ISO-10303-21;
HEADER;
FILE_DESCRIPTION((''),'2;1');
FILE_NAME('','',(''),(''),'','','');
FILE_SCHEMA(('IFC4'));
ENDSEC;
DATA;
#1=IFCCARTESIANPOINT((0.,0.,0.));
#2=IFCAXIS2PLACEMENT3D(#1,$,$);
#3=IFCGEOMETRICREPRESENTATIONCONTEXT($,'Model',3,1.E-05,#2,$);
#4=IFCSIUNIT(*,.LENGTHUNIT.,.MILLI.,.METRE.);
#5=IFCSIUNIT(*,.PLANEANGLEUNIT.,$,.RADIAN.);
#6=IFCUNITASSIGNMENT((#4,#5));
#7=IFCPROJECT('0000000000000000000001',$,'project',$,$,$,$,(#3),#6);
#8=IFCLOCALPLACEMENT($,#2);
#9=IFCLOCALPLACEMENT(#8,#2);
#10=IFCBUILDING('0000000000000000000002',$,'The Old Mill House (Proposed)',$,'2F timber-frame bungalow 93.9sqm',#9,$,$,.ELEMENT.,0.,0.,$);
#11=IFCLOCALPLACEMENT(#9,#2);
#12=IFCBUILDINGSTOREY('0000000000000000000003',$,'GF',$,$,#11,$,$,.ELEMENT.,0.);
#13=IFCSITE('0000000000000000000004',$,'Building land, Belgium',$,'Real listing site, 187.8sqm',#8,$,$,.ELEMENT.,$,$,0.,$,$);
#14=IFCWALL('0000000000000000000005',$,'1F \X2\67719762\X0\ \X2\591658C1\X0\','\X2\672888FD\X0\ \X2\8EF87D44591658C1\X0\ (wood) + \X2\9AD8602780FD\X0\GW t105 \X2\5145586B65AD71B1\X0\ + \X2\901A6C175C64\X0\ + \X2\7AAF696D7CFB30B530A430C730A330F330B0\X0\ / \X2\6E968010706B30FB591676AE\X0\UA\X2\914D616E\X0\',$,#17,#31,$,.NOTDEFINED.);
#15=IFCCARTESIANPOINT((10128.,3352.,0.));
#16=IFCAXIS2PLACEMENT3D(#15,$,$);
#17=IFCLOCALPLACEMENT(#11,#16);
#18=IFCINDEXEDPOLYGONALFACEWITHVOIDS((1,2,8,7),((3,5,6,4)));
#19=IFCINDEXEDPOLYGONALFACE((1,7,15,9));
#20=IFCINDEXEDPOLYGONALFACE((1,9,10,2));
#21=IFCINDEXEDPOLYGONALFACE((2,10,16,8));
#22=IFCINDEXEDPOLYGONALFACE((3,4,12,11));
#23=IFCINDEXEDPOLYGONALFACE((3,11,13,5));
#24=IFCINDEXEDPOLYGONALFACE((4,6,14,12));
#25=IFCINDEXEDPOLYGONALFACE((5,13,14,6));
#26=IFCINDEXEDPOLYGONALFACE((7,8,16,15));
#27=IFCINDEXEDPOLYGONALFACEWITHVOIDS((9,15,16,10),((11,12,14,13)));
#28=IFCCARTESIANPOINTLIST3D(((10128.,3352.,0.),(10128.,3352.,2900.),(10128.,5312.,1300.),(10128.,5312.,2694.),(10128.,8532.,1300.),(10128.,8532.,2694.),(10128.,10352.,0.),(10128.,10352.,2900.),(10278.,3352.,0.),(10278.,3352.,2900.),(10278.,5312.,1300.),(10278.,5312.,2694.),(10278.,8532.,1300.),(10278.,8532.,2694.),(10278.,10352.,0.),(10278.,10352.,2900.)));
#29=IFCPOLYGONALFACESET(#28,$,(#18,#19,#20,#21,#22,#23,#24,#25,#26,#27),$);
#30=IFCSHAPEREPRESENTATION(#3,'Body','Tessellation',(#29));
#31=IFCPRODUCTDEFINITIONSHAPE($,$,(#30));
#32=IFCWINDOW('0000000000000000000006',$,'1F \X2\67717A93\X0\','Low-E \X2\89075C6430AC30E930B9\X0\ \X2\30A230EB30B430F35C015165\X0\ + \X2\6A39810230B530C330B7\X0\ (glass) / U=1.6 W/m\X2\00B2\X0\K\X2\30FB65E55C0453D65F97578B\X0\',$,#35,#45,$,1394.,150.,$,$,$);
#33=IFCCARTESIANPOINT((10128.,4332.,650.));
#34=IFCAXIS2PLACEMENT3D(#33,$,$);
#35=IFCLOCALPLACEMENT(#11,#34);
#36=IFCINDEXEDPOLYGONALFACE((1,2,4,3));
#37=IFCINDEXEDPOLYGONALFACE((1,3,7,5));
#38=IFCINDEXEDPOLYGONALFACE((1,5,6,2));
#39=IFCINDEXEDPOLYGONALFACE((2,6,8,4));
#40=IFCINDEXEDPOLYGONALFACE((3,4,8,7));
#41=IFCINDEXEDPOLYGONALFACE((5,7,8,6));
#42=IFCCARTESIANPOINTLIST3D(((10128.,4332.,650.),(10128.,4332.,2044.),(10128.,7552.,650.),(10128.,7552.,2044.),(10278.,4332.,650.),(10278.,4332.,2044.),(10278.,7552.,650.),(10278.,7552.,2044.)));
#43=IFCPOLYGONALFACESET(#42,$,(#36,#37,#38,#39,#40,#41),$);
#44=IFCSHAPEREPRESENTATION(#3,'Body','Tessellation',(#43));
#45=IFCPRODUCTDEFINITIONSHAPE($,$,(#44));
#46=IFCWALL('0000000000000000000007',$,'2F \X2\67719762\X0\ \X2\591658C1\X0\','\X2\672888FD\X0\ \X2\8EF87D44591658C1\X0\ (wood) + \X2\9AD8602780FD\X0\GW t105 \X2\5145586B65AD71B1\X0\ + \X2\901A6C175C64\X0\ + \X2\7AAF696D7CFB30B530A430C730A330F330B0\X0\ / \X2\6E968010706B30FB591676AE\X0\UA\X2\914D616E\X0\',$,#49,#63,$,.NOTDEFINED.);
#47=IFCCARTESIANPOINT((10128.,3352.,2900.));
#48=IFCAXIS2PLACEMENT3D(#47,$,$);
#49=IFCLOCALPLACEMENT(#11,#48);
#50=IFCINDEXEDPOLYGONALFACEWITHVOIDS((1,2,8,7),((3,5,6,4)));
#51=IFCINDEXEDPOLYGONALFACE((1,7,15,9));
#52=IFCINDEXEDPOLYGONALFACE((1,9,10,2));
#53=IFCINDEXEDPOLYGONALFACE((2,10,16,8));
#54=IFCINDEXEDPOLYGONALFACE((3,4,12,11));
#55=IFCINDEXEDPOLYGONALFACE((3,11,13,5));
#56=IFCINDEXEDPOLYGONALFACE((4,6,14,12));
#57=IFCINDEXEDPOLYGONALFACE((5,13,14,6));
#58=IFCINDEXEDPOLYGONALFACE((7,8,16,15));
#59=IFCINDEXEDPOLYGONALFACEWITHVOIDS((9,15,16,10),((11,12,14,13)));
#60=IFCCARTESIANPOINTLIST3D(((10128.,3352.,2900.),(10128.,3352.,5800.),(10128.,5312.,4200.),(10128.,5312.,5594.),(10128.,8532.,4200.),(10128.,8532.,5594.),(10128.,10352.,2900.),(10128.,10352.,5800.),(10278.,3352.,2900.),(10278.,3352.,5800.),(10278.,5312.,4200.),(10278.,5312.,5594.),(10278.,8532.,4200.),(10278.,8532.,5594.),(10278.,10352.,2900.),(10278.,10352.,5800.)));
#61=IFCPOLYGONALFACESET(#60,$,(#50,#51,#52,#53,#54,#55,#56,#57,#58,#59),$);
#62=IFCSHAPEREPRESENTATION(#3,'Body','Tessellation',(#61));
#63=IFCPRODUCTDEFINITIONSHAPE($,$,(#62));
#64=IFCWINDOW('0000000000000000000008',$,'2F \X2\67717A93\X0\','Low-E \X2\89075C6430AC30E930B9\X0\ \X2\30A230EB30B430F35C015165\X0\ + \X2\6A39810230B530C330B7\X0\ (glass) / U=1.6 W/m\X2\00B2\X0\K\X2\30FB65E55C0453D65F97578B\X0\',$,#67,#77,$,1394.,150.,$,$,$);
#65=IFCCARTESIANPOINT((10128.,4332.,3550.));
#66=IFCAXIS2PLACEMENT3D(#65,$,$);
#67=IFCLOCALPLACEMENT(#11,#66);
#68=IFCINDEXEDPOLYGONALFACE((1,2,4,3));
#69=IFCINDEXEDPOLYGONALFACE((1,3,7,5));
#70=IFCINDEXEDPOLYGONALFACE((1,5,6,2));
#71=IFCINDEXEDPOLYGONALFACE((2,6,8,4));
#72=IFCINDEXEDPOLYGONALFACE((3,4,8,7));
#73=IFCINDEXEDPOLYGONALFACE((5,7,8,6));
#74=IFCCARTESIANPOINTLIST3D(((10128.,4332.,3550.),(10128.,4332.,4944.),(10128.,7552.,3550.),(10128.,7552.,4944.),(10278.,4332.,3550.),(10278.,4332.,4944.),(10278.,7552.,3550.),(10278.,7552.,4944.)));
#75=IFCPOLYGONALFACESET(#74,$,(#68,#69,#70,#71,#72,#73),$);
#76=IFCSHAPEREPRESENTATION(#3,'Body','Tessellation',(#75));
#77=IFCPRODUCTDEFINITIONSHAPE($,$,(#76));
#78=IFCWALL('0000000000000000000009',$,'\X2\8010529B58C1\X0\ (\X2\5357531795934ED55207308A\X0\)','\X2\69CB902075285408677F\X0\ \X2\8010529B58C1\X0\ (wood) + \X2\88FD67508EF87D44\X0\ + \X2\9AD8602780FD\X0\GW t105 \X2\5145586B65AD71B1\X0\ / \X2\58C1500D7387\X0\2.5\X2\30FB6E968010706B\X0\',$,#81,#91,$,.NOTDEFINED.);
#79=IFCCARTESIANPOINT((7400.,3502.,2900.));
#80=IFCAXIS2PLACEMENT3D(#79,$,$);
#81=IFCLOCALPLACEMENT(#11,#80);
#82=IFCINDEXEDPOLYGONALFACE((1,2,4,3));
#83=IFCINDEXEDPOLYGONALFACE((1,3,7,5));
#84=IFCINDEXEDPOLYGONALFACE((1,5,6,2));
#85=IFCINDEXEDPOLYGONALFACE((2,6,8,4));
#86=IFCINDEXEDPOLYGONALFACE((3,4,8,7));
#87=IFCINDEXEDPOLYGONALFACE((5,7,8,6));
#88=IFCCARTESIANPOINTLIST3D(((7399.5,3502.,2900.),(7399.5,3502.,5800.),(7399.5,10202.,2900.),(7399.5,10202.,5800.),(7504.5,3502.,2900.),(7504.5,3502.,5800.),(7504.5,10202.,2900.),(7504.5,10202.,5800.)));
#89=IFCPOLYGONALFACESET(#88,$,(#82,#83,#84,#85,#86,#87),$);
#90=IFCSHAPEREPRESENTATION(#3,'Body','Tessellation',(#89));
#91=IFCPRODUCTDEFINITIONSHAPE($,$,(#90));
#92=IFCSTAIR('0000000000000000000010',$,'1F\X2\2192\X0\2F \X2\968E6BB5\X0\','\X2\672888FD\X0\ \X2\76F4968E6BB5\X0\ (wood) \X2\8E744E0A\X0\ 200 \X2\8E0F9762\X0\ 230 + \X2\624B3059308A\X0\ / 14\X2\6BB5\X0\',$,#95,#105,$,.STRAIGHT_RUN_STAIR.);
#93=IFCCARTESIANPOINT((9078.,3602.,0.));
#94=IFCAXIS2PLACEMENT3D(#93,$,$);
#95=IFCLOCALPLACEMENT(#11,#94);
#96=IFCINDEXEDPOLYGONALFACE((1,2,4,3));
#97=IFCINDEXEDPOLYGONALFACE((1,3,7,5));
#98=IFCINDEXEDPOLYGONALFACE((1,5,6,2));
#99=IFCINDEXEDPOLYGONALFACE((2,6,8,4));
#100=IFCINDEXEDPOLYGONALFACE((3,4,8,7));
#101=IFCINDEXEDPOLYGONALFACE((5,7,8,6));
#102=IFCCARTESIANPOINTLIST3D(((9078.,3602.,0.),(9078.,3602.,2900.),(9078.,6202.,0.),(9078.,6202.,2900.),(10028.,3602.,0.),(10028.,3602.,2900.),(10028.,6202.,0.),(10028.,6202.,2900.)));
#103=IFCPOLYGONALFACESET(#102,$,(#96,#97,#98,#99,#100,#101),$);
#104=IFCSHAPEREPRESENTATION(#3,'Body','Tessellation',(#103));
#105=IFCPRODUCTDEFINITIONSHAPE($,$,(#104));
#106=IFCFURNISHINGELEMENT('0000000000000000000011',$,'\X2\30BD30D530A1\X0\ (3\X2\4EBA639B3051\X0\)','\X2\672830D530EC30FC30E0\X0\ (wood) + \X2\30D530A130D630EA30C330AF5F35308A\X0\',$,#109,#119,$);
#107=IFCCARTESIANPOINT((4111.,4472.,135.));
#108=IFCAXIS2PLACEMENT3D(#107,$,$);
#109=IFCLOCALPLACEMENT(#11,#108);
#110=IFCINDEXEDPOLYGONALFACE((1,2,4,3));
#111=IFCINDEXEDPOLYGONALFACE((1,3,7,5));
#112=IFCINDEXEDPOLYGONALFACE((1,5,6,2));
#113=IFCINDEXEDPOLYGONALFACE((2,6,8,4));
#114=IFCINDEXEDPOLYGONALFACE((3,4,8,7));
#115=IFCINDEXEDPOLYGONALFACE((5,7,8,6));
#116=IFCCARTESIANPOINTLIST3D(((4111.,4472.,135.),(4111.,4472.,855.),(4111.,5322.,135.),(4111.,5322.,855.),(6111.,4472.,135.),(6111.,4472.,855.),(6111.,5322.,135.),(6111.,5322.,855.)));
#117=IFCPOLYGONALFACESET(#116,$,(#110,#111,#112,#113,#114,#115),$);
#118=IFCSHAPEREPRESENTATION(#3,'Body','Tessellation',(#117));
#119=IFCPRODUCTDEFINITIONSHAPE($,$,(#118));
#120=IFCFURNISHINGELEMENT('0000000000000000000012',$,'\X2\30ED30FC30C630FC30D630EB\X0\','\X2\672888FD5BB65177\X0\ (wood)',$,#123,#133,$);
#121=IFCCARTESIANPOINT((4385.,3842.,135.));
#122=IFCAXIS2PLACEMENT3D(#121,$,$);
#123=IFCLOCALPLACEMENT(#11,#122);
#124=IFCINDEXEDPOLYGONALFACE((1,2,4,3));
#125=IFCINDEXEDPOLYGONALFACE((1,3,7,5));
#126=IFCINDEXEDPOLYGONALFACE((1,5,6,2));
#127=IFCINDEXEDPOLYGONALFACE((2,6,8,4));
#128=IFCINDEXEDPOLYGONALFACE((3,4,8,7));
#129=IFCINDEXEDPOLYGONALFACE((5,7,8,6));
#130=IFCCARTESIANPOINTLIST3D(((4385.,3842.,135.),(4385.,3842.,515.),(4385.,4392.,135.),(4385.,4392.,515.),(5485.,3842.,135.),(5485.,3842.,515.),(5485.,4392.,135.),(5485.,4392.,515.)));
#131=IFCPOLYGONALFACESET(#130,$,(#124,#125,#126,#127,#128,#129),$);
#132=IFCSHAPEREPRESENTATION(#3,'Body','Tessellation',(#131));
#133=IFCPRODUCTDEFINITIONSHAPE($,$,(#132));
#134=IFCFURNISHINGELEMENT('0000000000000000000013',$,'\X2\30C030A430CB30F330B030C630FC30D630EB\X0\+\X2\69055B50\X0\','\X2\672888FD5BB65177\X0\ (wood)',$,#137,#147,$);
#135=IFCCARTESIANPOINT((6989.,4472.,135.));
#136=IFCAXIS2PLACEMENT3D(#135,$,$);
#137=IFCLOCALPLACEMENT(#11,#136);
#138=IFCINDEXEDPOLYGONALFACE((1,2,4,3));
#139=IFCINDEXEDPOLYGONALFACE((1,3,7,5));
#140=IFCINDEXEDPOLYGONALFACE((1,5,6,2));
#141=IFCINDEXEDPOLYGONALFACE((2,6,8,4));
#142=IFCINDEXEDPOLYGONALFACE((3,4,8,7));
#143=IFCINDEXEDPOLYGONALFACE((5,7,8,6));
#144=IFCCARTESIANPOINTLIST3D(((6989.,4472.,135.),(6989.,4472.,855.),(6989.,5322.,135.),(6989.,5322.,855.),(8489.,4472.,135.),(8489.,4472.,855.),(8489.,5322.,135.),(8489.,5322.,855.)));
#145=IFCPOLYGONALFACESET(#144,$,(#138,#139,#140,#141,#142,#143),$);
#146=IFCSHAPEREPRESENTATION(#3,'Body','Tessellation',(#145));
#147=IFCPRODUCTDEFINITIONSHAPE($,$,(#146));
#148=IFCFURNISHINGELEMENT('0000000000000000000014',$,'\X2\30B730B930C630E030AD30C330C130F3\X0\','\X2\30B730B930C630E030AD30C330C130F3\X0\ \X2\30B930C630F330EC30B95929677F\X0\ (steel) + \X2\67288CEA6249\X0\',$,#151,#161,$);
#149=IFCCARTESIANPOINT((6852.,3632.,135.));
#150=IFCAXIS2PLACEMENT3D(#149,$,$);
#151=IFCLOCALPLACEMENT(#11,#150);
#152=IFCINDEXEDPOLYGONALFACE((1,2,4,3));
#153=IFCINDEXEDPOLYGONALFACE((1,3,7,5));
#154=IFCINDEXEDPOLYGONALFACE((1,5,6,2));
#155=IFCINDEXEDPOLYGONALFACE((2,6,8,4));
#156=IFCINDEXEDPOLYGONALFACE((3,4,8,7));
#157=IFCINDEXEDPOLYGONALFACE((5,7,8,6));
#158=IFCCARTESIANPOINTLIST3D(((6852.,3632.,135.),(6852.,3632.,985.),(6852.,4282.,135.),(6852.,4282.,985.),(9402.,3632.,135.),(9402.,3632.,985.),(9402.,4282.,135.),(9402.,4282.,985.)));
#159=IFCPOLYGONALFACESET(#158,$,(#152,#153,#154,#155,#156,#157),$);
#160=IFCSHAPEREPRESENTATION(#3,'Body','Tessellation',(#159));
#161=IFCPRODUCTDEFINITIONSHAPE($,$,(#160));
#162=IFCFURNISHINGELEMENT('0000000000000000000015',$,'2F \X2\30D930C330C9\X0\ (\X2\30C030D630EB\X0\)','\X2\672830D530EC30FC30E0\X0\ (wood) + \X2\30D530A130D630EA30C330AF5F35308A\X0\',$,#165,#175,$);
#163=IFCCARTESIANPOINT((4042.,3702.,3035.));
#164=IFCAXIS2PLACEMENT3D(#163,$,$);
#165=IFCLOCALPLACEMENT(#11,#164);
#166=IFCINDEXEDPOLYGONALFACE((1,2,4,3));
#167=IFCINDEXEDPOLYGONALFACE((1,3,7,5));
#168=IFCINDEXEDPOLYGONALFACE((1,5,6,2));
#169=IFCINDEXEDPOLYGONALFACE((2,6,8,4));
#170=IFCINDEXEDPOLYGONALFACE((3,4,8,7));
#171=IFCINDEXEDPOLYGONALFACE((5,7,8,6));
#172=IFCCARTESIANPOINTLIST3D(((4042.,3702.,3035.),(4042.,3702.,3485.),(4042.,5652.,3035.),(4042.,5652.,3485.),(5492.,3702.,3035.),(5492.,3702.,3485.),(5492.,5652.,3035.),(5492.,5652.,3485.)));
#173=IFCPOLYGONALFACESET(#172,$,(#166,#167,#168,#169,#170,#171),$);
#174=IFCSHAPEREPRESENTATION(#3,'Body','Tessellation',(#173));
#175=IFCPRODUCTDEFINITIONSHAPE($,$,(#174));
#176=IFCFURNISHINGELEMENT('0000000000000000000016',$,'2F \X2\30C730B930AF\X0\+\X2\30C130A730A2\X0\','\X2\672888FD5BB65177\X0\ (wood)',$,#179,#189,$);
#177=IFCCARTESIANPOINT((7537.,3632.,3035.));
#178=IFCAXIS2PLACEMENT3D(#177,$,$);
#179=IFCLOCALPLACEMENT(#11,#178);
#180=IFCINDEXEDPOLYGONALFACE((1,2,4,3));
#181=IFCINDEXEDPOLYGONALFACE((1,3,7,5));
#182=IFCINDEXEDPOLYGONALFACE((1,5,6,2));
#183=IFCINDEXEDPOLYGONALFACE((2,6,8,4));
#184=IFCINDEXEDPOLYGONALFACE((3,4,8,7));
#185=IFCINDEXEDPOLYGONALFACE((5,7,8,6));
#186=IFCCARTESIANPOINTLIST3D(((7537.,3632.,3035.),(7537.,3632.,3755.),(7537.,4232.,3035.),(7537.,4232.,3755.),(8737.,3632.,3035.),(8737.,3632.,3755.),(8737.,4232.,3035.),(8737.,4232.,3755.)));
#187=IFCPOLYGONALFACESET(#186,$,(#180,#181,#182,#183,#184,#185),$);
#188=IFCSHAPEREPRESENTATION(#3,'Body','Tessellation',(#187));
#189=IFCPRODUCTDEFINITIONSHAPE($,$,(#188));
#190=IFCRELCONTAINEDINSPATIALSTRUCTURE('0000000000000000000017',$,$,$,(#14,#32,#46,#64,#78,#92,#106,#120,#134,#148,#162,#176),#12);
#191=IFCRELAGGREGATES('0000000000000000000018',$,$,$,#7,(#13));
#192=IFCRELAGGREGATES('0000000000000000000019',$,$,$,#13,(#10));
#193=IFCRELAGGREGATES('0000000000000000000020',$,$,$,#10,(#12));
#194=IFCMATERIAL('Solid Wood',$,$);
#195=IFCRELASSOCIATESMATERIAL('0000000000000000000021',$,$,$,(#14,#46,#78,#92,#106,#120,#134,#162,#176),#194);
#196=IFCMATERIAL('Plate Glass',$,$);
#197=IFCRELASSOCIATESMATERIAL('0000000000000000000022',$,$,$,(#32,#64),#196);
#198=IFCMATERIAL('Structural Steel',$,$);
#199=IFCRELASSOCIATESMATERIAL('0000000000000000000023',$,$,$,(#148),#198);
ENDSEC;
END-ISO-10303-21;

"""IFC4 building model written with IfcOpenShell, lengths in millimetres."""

from ifc_helpers import new_model, si_unit, frame, frame_2d, origin, place, context, project, spatial, rectangle, extrude, material, element, fill, save


model = new_model("IFC4")

# Units and contexts
model_context = context("Model", 3, precision=1e-05, world=origin())
ifc_project = project(units=[si_unit("LENGTHUNIT", "METRE", prefix="MILLI"), si_unit("PLANEANGLEUNIT", "RADIAN")], contexts=[model_context])

# Site, building, storey
site_placement = place(None, origin())
site = spatial("IfcSite", under=ifc_project, at=site_placement, Name="Building land, Belgium", ObjectType="Real listing site, 187.8sqm", CompositionType="ELEMENT", RefElevation=0.0)
building_placement = place(site_placement, origin())
building = spatial("IfcBuilding", under=site, at=building_placement, Name="The Old Mill House (Proposed)", ObjectType="2F timber-frame bungalow 93.9sqm", CompositionType="ELEMENT", ElevationOfRefHeight=0.0, ElevationOfTerrain=0.0)
storey_placement = place(building_placement, origin())
storey = spatial("IfcBuildingStorey", under=building, at=storey_placement, Name="GF", CompositionType="ELEMENT", Elevation=0.0)

# Wall, opening, window
ifc_material_1 = material(Name="Solid Wood")
wall_1_placement = place(storey_placement, frame((10128.0, 3352.0, 0.0)))
wall_1 = element("IfcWall", 1, at=wall_1_placement, inside=storey, material=ifc_material_1, Name="1F 東面 外壁", Description="木製 軸組外壁 (wood) + 高性能GW t105 充填断熱 + 通気層 + 窯業系サイディング / 準耐火・外皮UA配慮", PredefinedType="NOTDEFINED", context=model_context, shape_type="SweptSolid", body=[
    extrude(rectangle(XDim=150.0, YDim=7000.0, at=frame_2d((75.0, 3500.0))), frame((10128.0, 3352.0, 0.0)), (0.0, 0.0, 1.0), 2900.0),
])
opening_1_placement = place(storey_placement, frame((10128.0, 4332.0, 650.0)))
opening_1 = element("IfcOpeningElement", 2, at=opening_1_placement, cuts=wall_1, PredefinedType="NOTDEFINED", context=model_context, shape_type="SweptSolid", body=[
    extrude(rectangle(XDim=150.0, YDim=3220.0, at=frame_2d((75.0, 1610.0))), frame((10128.0, 4332.0, 650.0)), (0.0, 0.0, 1.0), 1394.0),
])
ifc_material_2 = material(Name="Plate Glass")
window_1_placement = place(storey_placement, frame((10128.0, 4332.0, 650.0)))
window_1 = element("IfcWindow", 3, at=window_1_placement, inside=storey, material=ifc_material_2, Name="1F 東窓", Description="Low-E 複層ガラス アルゴン封入 + 樹脂サッシ (glass) / U=1.6 W/m²K・日射取得型", OverallHeight=1394.0, OverallWidth=150.0, context=model_context, shape_type="SweptSolid", body=[
    extrude(rectangle(XDim=150.0, YDim=3220.0, at=frame_2d((75.0, 1610.0))), frame((10128.0, 4332.0, 650.0)), (0.0, 0.0, 1.0), 1394.0),
])
fill(opening_1, window_1)

# Wall, opening, window
wall_2_placement = place(storey_placement, frame((10128.0, 3352.0, 2900.0)))
wall_2 = element("IfcWall", 4, at=wall_2_placement, inside=storey, material=ifc_material_1, Name="2F 東面 外壁", Description="木製 軸組外壁 (wood) + 高性能GW t105 充填断熱 + 通気層 + 窯業系サイディング / 準耐火・外皮UA配慮", PredefinedType="NOTDEFINED", context=model_context, shape_type="SweptSolid", body=[
    extrude(rectangle(XDim=150.0, YDim=7000.0, at=frame_2d((75.0, 3500.0))), frame((10128.0, 3352.0, 2900.0)), (0.0, 0.0, 1.0), 2900.0),
])
opening_2_placement = place(storey_placement, frame((10128.0, 4332.0, 3550.0)))
opening_2 = element("IfcOpeningElement", 5, at=opening_2_placement, cuts=wall_2, PredefinedType="NOTDEFINED", context=model_context, shape_type="SweptSolid", body=[
    extrude(rectangle(XDim=150.0, YDim=3220.0, at=frame_2d((75.0, 1610.0))), frame((10128.0, 4332.0, 3550.0)), (0.0, 0.0, 1.0), 1394.0),
])
window_2_placement = place(storey_placement, frame((10128.0, 4332.0, 3550.0)))
window_2 = element("IfcWindow", 6, at=window_2_placement, inside=storey, material=ifc_material_2, Name="2F 東窓", Description="Low-E 複層ガラス アルゴン封入 + 樹脂サッシ (glass) / U=1.6 W/m²K・日射取得型", OverallHeight=1394.0, OverallWidth=150.0, context=model_context, shape_type="SweptSolid", body=[
    extrude(rectangle(XDim=150.0, YDim=3220.0, at=frame_2d((75.0, 1610.0))), frame((10128.0, 4332.0, 3550.0)), (0.0, 0.0, 1.0), 1394.0),
])
fill(opening_2, window_2)

# Wall
wall_3_placement = place(storey_placement, frame((7400.0, 3502.0, 2900.0)))
element("IfcWall", 7, at=wall_3_placement, inside=storey, material=ifc_material_1, Name="耐力壁 (南北間仕切り)", Description="構造用合板 耐力壁 (wood) + 製材軸組 + 高性能GW t105 充填断熱 / 壁倍率2.5・準耐火", PredefinedType="NOTDEFINED", context=model_context, shape_type="SweptSolid", body=[
    extrude(rectangle(XDim=105.0, YDim=6700.0, at=frame_2d((52.0, 3350.0))), frame((7400.0, 3502.0, 2900.0)), (0.0, 0.0, 1.0), 2900.0),
])

# Stair
stair_placement = place(storey_placement, frame((9078.0, 3602.0, 0.0)))
element("IfcStair", 8, at=stair_placement, inside=storey, material=ifc_material_1, Name="1F→2F 階段", Description="木製 直階段 (wood) 蹴上 200 踏面 230 + 手すり / 14段", PredefinedType="STRAIGHT_RUN_STAIR", context=model_context, shape_type="SweptSolid", body=[
    extrude(rectangle(XDim=950.0, YDim=2600.0, at=frame_2d((475.0, 1300.0))), frame((9078.0, 3602.0, 0.0)), (0.0, 0.0, 1.0), 2900.0),
])

# Furnishing elements
furnishing_1_placement = place(storey_placement, frame((4111.0, 4472.0, 135.0)))
element("IfcFurnishingElement", 9, at=furnishing_1_placement, inside=storey, material=ifc_material_1, Name="ソファ (3人掛け)", Description="木フレーム (wood) + ファブリック張り", context=model_context, shape_type="SweptSolid", body=[
    extrude(rectangle(XDim=2000.0, YDim=850.0, at=frame_2d((1000.0, 425.0))), frame((4111.0, 4472.0, 135.0)), (0.0, 0.0, 1.0), 720.0),
])
furnishing_2_placement = place(storey_placement, frame((4385.0, 3842.0, 135.0)))
element("IfcFurnishingElement", 10, at=furnishing_2_placement, inside=storey, material=ifc_material_1, Name="ローテーブル", Description="木製家具 (wood)", context=model_context, shape_type="SweptSolid", body=[
    extrude(rectangle(XDim=1100.0, YDim=550.0, at=frame_2d((550.0, 275.0))), frame((4385.0, 3842.0, 135.0)), (0.0, 0.0, 1.0), 380.0),
])
furnishing_3_placement = place(storey_placement, frame((6989.0, 4472.0, 135.0)))
element("IfcFurnishingElement", 11, at=furnishing_3_placement, inside=storey, material=ifc_material_1, Name="ダイニングテーブル+椅子", Description="木製家具 (wood)", context=model_context, shape_type="SweptSolid", body=[
    extrude(rectangle(XDim=1500.0, YDim=850.0, at=frame_2d((750.0, 425.0))), frame((6989.0, 4472.0, 135.0)), (0.0, 0.0, 1.0), 720.0),
])
ifc_material_3 = material(Name="Structural Steel")
furnishing_4_placement = place(storey_placement, frame((6852.0, 3632.0, 135.0)))
element("IfcFurnishingElement", 12, at=furnishing_4_placement, inside=storey, material=ifc_material_3, Name="システムキッチン", Description="システムキッチン ステンレス天板 (steel) + 木質扉", context=model_context, shape_type="SweptSolid", body=[
    extrude(rectangle(XDim=2550.0, YDim=650.0, at=frame_2d((1275.0, 325.0))), frame((6852.0, 3632.0, 135.0)), (0.0, 0.0, 1.0), 850.0),
])
furnishing_5_placement = place(storey_placement, frame((4042.0, 3702.0, 3035.0)))
element("IfcFurnishingElement", 13, at=furnishing_5_placement, inside=storey, material=ifc_material_1, Name="2F ベッド (ダブル)", Description="木フレーム (wood) + ファブリック張り", context=model_context, shape_type="SweptSolid", body=[
    extrude(rectangle(XDim=1450.0, YDim=1950.0, at=frame_2d((725.0, 975.0))), frame((4042.0, 3702.0, 3035.0)), (0.0, 0.0, 1.0), 450.0),
])
furnishing_6_placement = place(storey_placement, frame((7537.0, 3632.0, 3035.0)))
element("IfcFurnishingElement", 14, at=furnishing_6_placement, inside=storey, material=ifc_material_1, Name="2F デスク+チェア", Description="木製家具 (wood)", context=model_context, shape_type="SweptSolid", body=[
    extrude(rectangle(XDim=1200.0, YDim=600.0, at=frame_2d((600.0, 300.0))), frame((7537.0, 3632.0, 3035.0)), (0.0, 0.0, 1.0), 720.0),
])

save(model, "model.ifc")
